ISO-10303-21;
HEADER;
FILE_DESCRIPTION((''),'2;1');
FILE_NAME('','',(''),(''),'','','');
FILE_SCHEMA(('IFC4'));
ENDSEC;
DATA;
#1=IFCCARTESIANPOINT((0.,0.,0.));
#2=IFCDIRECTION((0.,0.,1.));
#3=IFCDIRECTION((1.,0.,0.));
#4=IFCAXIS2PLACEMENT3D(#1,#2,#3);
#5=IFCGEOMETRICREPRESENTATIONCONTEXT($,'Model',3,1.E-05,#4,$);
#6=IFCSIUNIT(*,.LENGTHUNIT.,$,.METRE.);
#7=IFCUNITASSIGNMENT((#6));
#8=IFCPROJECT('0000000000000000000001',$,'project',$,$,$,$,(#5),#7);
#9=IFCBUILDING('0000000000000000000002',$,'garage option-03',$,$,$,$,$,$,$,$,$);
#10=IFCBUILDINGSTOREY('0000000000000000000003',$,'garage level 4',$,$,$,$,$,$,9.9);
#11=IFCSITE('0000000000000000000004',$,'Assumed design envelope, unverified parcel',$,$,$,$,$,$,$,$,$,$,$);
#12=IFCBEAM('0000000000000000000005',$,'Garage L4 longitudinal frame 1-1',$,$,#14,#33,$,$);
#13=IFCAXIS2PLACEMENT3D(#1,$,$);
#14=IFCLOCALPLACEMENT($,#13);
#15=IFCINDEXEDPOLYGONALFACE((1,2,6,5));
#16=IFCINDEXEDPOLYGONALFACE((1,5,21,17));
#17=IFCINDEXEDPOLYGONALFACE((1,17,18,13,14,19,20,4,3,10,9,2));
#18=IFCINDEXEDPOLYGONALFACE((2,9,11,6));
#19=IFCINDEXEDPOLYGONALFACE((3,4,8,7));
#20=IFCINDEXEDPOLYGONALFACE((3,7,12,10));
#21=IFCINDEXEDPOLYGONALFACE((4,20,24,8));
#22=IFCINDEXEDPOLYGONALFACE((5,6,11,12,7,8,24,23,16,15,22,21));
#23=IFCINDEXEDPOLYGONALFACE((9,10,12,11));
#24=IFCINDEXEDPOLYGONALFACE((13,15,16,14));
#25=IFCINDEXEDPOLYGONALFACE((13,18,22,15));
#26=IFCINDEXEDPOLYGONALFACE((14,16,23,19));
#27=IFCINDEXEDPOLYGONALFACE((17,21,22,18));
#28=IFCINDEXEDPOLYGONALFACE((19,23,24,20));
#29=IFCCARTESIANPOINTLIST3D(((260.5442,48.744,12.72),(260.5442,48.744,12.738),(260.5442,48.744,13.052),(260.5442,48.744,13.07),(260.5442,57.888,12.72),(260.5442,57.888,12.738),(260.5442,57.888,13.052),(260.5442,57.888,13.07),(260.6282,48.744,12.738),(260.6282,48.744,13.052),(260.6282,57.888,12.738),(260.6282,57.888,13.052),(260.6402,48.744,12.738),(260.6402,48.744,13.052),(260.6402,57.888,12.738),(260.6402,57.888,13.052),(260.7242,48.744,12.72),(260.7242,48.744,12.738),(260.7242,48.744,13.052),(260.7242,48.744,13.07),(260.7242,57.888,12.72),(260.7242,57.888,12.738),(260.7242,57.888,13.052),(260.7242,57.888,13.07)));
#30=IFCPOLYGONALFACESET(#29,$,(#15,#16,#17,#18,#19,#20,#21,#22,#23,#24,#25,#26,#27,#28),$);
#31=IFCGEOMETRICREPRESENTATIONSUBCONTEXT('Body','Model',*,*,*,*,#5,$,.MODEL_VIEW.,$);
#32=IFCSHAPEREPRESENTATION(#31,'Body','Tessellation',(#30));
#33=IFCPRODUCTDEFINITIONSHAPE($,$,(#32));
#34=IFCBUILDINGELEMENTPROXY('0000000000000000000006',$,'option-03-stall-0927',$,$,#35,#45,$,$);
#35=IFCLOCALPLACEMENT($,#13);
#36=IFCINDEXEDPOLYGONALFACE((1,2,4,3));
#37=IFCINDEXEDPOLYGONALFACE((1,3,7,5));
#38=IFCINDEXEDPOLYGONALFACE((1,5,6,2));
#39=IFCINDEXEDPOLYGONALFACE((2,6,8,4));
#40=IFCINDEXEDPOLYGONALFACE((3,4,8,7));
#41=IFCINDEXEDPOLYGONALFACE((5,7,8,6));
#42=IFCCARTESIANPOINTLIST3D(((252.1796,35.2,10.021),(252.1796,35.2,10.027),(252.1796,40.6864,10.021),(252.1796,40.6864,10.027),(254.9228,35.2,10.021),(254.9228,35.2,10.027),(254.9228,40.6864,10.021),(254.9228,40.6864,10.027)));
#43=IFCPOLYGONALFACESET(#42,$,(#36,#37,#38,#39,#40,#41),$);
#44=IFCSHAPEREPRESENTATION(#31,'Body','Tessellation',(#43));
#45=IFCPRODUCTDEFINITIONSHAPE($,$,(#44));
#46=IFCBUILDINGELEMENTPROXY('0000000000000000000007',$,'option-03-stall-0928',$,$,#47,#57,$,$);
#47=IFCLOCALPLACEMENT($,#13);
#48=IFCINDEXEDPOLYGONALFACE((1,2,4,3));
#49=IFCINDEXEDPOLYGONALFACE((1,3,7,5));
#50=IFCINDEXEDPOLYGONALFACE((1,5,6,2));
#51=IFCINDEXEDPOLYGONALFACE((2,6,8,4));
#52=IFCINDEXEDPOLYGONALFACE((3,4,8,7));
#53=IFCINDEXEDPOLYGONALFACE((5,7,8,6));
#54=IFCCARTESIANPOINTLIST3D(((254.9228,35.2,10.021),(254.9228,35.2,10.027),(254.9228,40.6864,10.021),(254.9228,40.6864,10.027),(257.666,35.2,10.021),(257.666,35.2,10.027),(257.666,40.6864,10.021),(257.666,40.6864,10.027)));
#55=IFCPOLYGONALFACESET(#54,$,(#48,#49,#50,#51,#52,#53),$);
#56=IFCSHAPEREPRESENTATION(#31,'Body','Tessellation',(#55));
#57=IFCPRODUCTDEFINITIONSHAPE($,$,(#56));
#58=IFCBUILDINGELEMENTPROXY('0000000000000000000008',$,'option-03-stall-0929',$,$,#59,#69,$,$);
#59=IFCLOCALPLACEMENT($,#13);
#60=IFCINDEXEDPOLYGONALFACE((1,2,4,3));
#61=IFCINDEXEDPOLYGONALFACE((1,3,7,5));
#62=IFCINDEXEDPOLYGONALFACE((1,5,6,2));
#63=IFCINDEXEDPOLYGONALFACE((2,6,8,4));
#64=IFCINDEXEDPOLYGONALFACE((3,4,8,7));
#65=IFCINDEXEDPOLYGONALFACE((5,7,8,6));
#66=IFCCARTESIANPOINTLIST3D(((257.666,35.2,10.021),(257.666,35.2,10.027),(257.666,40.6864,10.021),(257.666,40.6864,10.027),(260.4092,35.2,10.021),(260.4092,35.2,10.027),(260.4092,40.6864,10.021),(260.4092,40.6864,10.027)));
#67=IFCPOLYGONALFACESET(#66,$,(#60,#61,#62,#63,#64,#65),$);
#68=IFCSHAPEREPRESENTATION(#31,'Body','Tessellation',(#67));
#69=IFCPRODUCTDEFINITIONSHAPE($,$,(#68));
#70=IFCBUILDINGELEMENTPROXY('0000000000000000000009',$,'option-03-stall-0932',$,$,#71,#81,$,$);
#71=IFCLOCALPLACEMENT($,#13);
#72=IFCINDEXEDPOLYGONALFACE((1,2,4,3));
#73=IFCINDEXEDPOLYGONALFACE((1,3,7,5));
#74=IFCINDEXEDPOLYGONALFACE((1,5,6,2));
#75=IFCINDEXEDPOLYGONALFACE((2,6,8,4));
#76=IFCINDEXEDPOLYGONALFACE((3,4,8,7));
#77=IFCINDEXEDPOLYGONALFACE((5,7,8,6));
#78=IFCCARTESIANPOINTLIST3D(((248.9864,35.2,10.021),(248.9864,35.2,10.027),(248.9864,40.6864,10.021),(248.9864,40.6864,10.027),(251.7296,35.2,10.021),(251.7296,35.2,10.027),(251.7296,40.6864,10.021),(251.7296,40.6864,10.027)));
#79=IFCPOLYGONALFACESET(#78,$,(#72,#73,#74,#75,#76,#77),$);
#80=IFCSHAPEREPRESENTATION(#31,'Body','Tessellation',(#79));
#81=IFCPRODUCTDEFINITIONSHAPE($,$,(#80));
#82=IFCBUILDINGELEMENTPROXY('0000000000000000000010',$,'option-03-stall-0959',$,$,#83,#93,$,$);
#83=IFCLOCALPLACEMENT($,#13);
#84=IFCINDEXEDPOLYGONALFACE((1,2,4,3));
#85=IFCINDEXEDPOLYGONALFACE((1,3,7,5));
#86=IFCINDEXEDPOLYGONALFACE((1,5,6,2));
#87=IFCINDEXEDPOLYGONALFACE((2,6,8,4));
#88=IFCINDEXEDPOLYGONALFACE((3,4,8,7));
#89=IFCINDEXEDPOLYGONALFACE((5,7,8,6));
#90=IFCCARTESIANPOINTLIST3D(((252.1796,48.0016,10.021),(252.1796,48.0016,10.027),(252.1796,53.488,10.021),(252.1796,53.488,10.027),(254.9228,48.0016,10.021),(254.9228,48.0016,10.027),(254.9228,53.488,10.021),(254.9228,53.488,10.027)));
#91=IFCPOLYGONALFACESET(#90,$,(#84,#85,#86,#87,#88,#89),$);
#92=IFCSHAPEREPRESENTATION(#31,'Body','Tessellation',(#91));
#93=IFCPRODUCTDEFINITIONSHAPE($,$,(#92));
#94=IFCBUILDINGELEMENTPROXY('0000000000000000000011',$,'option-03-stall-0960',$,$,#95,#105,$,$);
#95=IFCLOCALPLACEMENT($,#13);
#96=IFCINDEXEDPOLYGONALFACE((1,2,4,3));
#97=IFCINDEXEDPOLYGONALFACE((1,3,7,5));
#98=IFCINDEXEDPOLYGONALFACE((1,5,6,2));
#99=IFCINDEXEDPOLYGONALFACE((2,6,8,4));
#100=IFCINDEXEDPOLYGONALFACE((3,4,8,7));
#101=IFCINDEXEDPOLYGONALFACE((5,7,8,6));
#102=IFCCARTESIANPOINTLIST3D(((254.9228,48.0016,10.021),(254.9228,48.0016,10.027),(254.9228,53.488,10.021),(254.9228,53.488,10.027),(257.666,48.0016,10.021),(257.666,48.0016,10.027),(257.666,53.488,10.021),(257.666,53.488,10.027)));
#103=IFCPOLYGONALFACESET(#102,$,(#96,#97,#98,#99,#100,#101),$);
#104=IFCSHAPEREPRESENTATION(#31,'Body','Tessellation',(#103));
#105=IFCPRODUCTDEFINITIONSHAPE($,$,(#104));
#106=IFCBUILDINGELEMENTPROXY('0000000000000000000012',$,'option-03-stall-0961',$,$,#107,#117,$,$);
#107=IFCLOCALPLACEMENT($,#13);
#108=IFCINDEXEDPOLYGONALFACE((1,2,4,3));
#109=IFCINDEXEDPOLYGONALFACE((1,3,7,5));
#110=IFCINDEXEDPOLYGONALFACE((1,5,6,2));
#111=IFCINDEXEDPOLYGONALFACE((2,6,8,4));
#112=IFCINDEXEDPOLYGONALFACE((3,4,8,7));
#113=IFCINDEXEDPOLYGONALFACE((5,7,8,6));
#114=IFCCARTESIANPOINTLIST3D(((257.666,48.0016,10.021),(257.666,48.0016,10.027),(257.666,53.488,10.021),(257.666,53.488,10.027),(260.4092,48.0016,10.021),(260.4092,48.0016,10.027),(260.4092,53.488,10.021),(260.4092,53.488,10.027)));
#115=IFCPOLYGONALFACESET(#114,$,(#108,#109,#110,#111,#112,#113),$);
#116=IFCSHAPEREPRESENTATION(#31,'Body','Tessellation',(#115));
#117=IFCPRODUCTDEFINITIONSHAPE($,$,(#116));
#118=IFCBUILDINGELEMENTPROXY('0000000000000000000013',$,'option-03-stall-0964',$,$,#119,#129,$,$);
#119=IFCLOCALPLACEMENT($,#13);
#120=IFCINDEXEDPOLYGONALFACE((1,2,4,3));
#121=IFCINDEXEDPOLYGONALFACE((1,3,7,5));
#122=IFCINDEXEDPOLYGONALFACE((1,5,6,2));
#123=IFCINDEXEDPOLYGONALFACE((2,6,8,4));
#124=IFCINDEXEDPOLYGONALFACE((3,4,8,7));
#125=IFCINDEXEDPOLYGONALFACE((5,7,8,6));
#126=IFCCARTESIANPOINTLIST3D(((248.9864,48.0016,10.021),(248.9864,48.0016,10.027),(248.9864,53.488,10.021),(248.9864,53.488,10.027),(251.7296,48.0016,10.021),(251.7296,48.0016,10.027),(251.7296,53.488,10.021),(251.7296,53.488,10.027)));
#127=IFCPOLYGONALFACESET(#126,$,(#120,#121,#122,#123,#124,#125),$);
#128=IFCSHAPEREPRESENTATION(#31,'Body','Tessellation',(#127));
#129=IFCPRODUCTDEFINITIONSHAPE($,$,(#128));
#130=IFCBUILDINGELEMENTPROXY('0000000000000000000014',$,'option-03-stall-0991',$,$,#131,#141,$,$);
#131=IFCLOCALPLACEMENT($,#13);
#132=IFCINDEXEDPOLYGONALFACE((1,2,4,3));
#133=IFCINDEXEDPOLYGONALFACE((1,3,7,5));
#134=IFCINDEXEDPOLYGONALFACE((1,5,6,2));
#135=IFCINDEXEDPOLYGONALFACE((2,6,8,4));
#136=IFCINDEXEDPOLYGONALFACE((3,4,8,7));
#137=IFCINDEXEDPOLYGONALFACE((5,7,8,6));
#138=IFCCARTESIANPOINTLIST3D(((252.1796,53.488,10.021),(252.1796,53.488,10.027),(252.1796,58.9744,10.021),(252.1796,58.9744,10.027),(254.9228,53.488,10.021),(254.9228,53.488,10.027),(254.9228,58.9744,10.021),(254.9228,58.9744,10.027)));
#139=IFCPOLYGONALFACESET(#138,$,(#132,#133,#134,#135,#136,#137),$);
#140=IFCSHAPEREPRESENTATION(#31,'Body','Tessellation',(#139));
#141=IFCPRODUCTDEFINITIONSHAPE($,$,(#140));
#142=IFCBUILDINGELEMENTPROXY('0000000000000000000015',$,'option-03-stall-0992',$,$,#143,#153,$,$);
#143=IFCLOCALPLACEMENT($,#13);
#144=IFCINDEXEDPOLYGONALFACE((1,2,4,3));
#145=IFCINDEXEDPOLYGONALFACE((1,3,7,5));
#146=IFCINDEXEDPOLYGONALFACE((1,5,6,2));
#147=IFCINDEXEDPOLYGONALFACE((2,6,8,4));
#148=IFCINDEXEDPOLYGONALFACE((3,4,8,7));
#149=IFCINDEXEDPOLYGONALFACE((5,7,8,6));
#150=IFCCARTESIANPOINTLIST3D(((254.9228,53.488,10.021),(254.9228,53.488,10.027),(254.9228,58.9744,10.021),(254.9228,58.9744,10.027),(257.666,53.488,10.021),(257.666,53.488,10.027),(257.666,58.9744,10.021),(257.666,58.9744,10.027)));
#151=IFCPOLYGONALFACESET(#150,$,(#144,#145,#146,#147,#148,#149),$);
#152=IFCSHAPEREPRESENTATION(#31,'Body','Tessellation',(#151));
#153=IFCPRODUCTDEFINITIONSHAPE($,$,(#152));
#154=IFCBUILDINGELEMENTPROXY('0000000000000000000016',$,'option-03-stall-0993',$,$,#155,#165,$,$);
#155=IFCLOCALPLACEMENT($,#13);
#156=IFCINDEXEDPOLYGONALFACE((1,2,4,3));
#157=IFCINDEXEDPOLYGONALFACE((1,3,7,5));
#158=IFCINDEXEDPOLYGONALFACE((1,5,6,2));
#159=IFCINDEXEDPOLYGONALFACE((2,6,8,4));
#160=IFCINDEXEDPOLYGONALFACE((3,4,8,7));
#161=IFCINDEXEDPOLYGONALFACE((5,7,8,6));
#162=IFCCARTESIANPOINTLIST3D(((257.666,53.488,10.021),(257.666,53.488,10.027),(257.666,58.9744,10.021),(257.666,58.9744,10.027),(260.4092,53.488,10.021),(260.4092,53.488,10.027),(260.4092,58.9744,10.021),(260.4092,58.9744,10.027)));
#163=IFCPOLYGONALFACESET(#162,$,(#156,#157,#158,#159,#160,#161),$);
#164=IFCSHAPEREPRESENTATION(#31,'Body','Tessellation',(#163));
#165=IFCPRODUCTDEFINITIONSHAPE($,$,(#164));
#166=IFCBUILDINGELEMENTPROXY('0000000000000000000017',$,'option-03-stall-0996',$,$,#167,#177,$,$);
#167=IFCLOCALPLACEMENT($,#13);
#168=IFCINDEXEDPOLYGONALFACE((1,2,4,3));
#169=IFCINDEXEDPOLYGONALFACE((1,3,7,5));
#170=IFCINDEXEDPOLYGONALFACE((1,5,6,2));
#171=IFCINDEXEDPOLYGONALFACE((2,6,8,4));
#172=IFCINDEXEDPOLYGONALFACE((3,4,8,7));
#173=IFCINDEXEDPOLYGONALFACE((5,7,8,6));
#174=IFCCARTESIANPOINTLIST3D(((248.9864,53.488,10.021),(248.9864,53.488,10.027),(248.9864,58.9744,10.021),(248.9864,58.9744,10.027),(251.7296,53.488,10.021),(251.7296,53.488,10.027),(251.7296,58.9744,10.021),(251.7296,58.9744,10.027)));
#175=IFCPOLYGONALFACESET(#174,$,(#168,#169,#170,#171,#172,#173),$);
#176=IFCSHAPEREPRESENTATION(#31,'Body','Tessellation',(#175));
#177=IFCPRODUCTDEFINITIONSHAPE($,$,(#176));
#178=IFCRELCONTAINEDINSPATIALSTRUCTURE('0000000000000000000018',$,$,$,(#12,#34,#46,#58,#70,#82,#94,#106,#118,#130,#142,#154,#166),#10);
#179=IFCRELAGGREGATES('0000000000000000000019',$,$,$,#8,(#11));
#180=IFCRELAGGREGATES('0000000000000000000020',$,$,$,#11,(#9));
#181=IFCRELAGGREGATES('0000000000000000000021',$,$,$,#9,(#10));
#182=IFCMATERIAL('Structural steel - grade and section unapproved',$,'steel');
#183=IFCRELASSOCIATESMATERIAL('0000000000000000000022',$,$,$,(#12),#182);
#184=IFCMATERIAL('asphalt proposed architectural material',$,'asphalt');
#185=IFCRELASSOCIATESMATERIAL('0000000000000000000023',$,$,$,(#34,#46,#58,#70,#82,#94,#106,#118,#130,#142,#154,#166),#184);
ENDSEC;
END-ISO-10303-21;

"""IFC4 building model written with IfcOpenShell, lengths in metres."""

from ifc_helpers import new_model, si_unit, frame, origin_with_axes, place, context, subcontext, project, spatial, rectangle, i_section, extrude, material, element, save


model = new_model("IFC4")

# Units and contexts
model_context = context("Model", 3, precision=1e-05, world=origin_with_axes())
body_context = subcontext(model_context, "Body", "Model", "MODEL_VIEW")
ifc_project = project(units=[si_unit("LENGTHUNIT", "METRE")], contexts=[model_context])

# Site, building, storey
site = spatial("IfcSite", under=ifc_project, Name="Assumed design envelope, unverified parcel")
building = spatial("IfcBuilding", under=site, Name="garage option-03")
storey = spatial("IfcBuildingStorey", under=building, Name="garage level 4", Elevation=9.9)

# Beam
ifc_material_1 = material(Name="Structural steel - grade and section unapproved", Category="steel")
for number, where, z_axis, x_axis, name in (
    (1, (260.6342, 48.744, 12.895), (0.0, 1.0, 0.0), (-1.0, 0.0, 0.0), "Garage L4 longitudinal frame 1-1"),
):
    element("IfcBeam", number, at=place(None, frame(where, z_axis=z_axis, x_axis=x_axis)), inside=storey, material=ifc_material_1, Name=name, context=body_context, shape_type="SweptSolid", body=[
        extrude(i_section(OverallWidth=0.18, OverallDepth=0.35, WebThickness=0.012, FlangeThickness=0.018, FilletRadius=0.0), origin_with_axes(), (0.0, 0.0, 1.0), 9.144),
    ])

# Building element proxies
ifc_material_2 = material(Name="asphalt proposed architectural material", Category="asphalt")
for number, where, z_axis, x_axis, name in (
    (2, (253.5512, 37.9432, 10.021), (0.0, 0.0, 1.0), (1.0, 0.0, 0.0), "option-03-stall-0927"),
    (3, (256.2944, 37.9432, 10.021), (0.0, 0.0, 1.0), (1.0, 0.0, 0.0), "option-03-stall-0928"),
    (4, (259.0376, 37.9432, 10.021), (0.0, 0.0, 1.0), (1.0, 0.0, 0.0), "option-03-stall-0929"),
    (5, (250.358, 37.9432, 10.021), (0.0, 0.0, 1.0), (1.0, 0.0, 0.0), "option-03-stall-0932"),
    (6, (253.5512, 50.7448, 10.021), (0.0, 0.0, 1.0), (1.0, 0.0, 0.0), "option-03-stall-0959"),
    (7, (256.2944, 50.7448, 10.021), (0.0, 0.0, 1.0), (1.0, 0.0, 0.0), "option-03-stall-0960"),
    (8, (259.0376, 50.7448, 10.021), (0.0, 0.0, 1.0), (1.0, 0.0, 0.0), "option-03-stall-0961"),
    (9, (250.358, 50.7448, 10.021), (0.0, 0.0, 1.0), (1.0, 0.0, 0.0), "option-03-stall-0964"),
):
    element("IfcBuildingElementProxy", number, at=place(None, frame(where, z_axis=z_axis, x_axis=x_axis)), inside=storey, material=ifc_material_2, Name=name, context=body_context, shape_type="SweptSolid", body=[
        extrude(rectangle(XDim=2.7432, YDim=5.4864), origin_with_axes(), (0.0, 0.0, 1.0), 0.006),
    ])
for number, where, z_axis, x_axis, name in (
    (10, (253.5512, 56.2312, 10.021), (0.0, 0.0, 1.0), (1.0, 0.0, 0.0), "option-03-stall-0991"),
    (11, (256.2944, 56.2312, 10.021), (0.0, 0.0, 1.0), (1.0, 0.0, 0.0), "option-03-stall-0992"),
    (12, (259.0376, 56.2312, 10.021), (0.0, 0.0, 1.0), (1.0, 0.0, 0.0), "option-03-stall-0993"),
    (13, (250.358, 56.2312, 10.021), (0.0, 0.0, 1.0), (1.0, 0.0, 0.0), "option-03-stall-0996"),
):
    element("IfcBuildingElementProxy", number, at=place(None, frame(where, z_axis=z_axis, x_axis=x_axis)), inside=storey, material=ifc_material_2, Name=name, context=body_context, shape_type="SweptSolid", body=[
        extrude(rectangle(XDim=2.7432, YDim=5.4864), origin_with_axes(), (0.0, 0.0, 1.0), 0.006),
    ])

save(model, "model.ifc")
